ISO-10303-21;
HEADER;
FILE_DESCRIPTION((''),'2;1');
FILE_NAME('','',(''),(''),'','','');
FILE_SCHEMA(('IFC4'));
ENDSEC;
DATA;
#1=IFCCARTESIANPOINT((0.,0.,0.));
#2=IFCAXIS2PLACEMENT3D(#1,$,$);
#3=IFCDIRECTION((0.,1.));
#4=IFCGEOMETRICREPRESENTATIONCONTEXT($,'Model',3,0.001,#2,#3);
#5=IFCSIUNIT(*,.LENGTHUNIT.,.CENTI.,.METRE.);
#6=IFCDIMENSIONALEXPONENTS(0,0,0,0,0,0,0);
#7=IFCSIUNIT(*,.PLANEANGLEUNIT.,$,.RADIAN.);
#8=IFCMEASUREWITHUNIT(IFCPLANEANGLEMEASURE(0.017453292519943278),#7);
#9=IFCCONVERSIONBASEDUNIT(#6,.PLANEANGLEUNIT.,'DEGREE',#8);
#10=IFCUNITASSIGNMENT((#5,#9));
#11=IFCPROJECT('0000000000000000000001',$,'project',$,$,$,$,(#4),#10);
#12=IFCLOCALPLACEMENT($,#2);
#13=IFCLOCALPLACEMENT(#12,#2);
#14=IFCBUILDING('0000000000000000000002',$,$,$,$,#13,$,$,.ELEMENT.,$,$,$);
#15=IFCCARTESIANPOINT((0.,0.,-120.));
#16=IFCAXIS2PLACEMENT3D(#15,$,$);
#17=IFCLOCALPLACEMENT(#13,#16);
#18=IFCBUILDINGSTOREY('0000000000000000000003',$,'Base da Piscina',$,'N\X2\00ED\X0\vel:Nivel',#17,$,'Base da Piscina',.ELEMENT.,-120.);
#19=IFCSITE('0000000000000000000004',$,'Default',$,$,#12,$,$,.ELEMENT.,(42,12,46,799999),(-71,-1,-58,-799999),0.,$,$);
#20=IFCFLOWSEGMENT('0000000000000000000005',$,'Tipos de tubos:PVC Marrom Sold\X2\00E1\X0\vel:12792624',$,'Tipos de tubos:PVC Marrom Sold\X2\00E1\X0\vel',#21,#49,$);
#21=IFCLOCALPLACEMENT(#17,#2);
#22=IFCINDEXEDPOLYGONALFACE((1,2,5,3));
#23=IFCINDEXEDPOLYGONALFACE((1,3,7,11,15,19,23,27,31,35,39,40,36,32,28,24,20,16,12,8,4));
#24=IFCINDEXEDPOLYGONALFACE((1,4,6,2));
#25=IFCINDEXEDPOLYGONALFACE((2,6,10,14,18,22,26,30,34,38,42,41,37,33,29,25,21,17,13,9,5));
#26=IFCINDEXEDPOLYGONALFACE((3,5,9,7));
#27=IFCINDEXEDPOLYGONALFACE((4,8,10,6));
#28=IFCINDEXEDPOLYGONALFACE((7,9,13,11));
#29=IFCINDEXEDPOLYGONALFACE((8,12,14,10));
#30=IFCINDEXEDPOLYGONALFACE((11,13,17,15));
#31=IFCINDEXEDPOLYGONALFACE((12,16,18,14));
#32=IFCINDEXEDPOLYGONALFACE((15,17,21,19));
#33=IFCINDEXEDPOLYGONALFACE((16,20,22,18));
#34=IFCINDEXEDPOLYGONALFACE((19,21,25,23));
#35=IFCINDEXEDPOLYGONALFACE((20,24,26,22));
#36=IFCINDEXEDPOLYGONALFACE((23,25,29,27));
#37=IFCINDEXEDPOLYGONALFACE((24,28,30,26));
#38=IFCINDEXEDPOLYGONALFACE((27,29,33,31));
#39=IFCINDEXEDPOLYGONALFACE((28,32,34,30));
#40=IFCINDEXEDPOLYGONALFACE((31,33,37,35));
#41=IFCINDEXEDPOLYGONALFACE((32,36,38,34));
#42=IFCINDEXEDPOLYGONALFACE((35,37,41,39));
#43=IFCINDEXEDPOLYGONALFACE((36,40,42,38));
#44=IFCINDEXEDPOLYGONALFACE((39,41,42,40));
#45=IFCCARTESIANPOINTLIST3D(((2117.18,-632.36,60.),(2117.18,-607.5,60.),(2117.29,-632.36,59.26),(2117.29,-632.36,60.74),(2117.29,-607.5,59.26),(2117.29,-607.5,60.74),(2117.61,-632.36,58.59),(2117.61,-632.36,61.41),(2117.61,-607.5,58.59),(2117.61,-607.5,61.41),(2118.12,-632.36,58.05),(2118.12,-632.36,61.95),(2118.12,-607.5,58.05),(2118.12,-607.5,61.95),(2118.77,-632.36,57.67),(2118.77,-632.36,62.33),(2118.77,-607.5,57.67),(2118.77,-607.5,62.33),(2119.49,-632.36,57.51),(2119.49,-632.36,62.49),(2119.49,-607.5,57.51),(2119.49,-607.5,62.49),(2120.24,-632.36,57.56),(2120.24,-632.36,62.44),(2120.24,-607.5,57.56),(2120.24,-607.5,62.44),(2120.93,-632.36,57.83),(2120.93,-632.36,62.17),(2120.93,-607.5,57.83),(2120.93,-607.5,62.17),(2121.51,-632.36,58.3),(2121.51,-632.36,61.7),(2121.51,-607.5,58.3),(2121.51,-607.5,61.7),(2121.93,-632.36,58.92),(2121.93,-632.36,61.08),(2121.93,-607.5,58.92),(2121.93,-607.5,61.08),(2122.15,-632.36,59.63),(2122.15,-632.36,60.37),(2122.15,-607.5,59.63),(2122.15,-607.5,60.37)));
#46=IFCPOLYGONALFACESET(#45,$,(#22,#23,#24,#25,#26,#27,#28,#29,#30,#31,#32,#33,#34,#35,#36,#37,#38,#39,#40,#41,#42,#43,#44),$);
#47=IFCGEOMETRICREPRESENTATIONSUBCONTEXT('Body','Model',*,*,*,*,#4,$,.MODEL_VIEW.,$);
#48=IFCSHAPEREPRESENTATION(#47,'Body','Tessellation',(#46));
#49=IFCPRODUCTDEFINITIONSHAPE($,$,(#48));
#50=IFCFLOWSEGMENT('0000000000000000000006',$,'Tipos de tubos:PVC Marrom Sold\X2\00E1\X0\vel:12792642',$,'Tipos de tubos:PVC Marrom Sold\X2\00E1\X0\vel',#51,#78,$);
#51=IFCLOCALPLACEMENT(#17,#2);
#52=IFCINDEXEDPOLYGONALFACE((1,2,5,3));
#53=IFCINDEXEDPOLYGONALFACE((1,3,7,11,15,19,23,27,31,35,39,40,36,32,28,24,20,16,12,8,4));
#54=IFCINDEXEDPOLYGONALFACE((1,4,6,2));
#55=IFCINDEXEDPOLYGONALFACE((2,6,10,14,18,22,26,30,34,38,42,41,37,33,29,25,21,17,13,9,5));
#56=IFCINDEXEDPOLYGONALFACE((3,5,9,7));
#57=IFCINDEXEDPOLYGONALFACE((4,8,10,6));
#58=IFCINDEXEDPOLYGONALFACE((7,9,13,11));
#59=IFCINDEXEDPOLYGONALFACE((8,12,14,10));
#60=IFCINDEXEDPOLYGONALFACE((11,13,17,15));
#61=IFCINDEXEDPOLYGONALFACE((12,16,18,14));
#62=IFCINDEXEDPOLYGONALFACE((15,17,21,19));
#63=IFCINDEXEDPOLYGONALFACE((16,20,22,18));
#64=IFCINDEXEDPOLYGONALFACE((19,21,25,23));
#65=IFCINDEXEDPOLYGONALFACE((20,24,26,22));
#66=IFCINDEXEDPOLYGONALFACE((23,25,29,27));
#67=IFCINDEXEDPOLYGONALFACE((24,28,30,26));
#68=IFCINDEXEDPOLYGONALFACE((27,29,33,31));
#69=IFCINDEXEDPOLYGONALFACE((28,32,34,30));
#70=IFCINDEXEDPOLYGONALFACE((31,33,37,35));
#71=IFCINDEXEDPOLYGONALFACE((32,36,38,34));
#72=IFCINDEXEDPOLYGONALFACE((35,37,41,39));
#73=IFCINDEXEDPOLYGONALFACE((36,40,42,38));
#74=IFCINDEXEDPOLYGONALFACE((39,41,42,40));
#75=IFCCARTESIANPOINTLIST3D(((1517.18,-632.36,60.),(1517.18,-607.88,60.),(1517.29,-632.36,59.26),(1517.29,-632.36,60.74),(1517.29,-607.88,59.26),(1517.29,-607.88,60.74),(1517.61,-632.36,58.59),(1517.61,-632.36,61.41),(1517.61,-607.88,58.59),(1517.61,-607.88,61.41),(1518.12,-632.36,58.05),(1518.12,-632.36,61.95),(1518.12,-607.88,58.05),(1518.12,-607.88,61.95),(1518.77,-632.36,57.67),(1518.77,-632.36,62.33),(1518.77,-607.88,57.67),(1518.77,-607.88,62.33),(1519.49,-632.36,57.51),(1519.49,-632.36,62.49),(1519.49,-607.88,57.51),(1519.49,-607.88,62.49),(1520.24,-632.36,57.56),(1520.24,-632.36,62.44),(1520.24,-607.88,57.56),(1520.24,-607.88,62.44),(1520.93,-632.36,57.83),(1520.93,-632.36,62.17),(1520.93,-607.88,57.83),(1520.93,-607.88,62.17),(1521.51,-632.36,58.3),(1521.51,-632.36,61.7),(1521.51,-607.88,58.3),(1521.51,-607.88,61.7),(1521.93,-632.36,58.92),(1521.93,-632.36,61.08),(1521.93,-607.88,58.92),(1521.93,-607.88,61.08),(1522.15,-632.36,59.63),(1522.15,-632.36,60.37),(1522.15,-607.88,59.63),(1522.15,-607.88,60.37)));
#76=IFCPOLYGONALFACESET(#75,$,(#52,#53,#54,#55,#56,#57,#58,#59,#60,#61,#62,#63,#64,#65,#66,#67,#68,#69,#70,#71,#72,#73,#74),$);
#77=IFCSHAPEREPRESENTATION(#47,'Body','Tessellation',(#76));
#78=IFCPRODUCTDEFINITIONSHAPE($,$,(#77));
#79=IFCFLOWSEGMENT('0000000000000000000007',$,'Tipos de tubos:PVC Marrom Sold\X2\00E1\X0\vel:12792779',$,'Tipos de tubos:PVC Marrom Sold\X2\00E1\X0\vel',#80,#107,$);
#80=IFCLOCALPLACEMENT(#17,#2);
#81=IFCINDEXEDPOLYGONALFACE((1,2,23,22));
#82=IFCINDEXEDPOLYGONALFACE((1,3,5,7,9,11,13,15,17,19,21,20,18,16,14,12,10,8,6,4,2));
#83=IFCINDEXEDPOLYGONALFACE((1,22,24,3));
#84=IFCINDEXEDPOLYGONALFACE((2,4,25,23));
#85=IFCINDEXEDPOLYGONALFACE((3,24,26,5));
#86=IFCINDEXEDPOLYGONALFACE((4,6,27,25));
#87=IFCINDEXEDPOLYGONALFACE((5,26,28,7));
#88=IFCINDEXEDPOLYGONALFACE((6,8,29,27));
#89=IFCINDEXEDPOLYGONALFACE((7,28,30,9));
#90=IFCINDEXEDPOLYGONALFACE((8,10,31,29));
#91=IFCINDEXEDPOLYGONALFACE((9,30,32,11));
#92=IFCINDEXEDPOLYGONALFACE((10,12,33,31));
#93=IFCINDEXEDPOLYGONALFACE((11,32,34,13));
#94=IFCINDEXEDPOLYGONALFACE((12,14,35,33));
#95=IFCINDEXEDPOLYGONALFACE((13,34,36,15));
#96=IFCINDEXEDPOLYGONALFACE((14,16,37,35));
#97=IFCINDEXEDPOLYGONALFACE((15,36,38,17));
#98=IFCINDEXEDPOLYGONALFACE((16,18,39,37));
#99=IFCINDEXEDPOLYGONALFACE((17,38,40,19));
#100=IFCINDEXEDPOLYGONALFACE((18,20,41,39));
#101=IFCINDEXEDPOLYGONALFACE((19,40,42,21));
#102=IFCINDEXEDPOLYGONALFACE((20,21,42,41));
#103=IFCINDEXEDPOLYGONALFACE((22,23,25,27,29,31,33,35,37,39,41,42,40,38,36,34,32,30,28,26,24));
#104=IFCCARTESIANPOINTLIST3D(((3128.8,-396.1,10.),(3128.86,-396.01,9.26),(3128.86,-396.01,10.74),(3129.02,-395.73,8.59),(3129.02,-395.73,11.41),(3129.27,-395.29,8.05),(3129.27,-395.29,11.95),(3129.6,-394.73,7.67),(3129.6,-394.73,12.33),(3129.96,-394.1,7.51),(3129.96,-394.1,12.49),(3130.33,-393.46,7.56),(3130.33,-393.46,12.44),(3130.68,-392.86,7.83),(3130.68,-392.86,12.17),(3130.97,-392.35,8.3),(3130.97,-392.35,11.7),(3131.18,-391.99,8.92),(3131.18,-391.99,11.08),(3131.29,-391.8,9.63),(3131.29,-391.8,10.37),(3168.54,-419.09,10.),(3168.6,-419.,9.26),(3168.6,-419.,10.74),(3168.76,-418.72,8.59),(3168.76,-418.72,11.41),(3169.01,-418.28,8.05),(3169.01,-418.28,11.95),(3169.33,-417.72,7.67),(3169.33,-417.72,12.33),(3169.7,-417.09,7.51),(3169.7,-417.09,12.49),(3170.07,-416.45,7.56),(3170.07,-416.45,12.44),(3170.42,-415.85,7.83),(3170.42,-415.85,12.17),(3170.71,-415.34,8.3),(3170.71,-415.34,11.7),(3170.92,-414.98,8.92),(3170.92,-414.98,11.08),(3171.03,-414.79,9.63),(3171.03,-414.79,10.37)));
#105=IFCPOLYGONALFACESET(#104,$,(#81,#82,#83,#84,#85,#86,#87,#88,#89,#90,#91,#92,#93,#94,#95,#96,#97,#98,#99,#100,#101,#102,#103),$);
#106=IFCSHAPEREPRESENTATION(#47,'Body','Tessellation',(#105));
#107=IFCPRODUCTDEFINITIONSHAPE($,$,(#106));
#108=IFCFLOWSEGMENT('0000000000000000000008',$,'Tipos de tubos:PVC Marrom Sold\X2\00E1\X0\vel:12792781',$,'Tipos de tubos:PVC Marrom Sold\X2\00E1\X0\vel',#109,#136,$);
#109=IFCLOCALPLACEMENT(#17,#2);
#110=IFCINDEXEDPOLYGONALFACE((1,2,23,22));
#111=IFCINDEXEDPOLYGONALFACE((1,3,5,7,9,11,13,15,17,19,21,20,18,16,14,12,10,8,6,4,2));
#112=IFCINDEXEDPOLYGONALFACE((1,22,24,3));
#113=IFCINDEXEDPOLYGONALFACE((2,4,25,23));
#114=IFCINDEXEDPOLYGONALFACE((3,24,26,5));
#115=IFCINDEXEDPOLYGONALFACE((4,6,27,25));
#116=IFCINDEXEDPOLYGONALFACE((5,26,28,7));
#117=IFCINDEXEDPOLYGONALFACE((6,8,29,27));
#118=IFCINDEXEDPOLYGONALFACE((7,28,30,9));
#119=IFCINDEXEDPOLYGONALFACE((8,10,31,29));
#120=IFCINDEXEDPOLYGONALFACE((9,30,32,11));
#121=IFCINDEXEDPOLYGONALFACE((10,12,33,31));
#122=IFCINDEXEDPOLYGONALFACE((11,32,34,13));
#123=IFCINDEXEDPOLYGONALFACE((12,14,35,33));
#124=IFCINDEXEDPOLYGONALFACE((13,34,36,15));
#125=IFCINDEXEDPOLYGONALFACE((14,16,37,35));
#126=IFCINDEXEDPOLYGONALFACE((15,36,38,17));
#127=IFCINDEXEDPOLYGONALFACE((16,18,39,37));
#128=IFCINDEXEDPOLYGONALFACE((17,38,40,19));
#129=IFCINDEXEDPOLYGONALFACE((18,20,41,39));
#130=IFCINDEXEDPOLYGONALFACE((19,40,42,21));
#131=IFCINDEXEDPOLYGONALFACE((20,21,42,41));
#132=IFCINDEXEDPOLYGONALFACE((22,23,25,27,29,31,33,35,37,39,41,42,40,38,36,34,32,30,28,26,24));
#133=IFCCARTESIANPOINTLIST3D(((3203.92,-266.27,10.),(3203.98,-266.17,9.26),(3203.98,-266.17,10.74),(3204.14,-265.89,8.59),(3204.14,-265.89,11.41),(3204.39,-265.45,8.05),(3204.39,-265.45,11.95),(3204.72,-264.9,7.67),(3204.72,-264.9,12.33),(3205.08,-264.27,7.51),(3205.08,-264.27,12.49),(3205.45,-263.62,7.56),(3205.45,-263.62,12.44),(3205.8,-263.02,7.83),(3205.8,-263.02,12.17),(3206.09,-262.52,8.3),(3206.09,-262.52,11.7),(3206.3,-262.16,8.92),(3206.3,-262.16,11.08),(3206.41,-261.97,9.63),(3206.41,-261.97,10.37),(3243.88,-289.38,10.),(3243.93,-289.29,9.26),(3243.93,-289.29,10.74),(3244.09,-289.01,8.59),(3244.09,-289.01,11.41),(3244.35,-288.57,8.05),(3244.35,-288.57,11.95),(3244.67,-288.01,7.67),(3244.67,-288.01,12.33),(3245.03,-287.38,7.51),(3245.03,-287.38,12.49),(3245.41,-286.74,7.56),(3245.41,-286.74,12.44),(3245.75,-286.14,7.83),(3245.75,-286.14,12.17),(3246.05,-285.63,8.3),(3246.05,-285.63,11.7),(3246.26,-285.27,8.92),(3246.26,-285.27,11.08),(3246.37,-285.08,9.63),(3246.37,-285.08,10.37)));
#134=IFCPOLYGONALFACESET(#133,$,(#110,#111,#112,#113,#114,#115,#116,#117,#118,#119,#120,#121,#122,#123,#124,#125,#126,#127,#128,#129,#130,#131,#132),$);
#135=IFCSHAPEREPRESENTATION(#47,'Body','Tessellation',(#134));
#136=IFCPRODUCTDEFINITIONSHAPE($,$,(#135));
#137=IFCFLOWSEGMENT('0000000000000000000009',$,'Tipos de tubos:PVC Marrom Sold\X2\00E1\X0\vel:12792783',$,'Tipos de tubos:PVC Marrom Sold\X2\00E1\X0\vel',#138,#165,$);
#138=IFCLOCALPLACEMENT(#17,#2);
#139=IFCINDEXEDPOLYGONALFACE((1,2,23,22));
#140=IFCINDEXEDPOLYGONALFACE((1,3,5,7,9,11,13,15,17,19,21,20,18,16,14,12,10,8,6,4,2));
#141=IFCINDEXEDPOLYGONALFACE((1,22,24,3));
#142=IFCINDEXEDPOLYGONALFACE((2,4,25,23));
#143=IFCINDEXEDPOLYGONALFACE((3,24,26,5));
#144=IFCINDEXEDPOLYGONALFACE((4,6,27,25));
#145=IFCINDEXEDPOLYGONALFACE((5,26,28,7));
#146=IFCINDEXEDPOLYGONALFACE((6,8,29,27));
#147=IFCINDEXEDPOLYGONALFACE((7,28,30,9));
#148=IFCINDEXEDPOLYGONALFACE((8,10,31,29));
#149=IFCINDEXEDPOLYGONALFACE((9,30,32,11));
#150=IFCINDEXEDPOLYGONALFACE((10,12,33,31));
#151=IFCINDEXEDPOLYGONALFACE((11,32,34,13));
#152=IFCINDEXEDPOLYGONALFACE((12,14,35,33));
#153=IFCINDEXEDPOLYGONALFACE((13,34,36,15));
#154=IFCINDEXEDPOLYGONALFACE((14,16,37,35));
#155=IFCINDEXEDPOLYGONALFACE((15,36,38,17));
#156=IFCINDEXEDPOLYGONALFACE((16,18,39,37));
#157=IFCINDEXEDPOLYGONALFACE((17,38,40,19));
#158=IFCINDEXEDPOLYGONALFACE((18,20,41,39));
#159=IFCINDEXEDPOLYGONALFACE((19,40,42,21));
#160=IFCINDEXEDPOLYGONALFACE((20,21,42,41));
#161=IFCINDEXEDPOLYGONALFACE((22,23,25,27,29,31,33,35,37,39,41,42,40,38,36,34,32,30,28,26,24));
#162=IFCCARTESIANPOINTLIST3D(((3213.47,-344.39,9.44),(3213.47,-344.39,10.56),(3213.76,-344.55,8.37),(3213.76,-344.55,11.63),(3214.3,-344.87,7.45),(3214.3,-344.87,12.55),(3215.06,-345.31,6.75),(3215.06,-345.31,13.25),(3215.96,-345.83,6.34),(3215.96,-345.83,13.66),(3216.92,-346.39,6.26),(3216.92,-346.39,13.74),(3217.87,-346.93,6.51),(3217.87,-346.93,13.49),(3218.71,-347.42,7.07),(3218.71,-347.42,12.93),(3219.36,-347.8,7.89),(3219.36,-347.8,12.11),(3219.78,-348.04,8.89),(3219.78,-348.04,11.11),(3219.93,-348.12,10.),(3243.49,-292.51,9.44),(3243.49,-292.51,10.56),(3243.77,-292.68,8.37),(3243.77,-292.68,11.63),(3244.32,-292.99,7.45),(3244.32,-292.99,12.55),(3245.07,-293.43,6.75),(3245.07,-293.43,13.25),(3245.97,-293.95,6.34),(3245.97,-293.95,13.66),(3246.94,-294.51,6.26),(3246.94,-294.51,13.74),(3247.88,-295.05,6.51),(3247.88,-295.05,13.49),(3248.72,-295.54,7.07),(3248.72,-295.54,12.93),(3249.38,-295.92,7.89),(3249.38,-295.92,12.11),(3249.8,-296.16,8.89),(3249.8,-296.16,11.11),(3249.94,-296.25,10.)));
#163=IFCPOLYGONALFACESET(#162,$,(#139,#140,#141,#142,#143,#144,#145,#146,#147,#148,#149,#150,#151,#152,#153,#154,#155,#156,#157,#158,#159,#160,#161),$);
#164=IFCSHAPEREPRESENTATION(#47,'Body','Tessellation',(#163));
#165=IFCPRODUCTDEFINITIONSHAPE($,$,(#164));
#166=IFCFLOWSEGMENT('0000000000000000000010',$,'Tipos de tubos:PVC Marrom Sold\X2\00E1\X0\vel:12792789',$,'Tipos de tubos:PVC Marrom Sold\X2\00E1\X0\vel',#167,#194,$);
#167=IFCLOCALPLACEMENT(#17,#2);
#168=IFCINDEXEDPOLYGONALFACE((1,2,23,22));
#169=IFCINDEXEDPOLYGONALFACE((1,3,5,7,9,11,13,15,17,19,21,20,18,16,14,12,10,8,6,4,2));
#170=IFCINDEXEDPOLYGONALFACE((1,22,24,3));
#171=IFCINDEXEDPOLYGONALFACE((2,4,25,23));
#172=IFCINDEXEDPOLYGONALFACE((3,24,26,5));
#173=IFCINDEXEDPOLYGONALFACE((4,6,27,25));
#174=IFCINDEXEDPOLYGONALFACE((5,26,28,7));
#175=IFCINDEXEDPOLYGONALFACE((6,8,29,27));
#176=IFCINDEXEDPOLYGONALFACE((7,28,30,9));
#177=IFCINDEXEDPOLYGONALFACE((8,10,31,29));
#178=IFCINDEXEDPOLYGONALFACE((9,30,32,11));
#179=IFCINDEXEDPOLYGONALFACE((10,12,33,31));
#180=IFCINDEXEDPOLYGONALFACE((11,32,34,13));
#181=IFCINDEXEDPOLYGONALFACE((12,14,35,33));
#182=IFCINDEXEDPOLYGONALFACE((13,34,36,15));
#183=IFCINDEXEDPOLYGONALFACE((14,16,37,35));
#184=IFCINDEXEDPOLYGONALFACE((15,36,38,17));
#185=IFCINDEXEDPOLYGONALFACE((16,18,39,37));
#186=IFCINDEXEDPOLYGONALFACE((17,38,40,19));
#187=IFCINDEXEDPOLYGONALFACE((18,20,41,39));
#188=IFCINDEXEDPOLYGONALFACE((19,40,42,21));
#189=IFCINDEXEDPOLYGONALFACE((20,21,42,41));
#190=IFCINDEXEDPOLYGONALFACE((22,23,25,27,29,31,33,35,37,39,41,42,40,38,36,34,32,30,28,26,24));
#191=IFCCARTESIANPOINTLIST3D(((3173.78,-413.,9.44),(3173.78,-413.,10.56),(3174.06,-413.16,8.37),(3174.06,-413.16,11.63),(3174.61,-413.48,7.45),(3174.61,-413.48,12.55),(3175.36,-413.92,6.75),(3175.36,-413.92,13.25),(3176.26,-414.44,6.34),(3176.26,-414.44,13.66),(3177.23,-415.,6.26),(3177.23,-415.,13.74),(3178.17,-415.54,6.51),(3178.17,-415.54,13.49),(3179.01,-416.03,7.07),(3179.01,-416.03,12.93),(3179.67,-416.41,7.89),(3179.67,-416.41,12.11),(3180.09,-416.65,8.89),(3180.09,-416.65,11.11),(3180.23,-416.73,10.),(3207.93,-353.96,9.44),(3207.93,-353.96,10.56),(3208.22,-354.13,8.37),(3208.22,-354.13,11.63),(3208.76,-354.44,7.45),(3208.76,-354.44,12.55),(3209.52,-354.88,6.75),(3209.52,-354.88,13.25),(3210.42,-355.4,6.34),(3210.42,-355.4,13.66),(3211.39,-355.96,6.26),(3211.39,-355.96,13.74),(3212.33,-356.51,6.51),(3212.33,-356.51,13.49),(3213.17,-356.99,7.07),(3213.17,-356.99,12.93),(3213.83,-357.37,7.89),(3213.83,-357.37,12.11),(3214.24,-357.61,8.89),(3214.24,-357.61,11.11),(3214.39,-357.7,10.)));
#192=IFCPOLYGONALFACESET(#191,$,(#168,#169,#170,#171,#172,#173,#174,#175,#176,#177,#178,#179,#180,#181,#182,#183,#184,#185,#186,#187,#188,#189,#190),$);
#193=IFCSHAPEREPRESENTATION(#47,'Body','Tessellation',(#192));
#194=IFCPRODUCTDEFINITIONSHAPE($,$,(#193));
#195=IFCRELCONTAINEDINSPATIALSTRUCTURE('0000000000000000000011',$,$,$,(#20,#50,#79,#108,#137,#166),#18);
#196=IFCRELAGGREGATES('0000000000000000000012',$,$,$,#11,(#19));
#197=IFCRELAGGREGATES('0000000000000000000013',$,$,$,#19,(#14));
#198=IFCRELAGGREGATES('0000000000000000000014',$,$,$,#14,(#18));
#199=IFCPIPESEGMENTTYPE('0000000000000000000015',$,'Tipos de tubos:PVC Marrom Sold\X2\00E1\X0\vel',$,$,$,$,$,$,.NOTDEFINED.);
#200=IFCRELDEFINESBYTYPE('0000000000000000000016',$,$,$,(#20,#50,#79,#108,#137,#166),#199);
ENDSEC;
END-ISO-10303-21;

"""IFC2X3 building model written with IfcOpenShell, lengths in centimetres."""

from ifc_helpers import new_model, entity, si_unit, converted_unit, direction, frame, frame_2d, origin, origin_2d_with_axis, place, context, subcontext, project, spatial, circle, extrude, type_object, element, save


model = new_model("IFC2X3")

# Units and contexts
model_context = context("Model", 3, precision=0.001, world=origin(), true_north=direction((0.0, 1.0)))
body_context = subcontext(model_context, "Body", "Model", "MODEL_VIEW")
ifc_project = project(units=[si_unit("LENGTHUNIT", "METRE", prefix="CENTI"), converted_unit("PLANEANGLEUNIT", "DEGREE", entity("IfcPlaneAngleMeasure", 0.017453292519943278), si_unit("PLANEANGLEUNIT", "RADIAN"), dimensions=[0, 0, 0, 0, 0, 0, 0])], contexts=[model_context])

# Site, building, storey
site_placement = place(None, origin())
site = spatial("IfcSite", under=ifc_project, at=site_placement, Name="Default", CompositionType="ELEMENT", RefLatitude=(42, 12, 46, 799999), RefLongitude=(-71, -1, -58, -799999), RefElevation=0.0)
building_placement = place(site_placement, origin())
building = spatial("IfcBuilding", under=site, at=building_placement, CompositionType="ELEMENT")
storey_placement = place(building_placement, frame((0.0, 0.0, -120.0)))
storey = spatial("IfcBuildingStorey", under=building, at=storey_placement, Name="Base da Piscina", ObjectType="Nível:Nivel", LongName="Base da Piscina", CompositionType="ELEMENT", Elevation=-120.0)

# Flow segments
pipe_segment_type = type_object("IfcPipeSegmentType", Name="Tipos de tubos:PVC Marrom Soldável", PredefinedType="NOTDEFINED")
flow_segment_1_placement = place(storey_placement, origin())
element("IfcFlowSegment", 1, at=flow_segment_1_placement, inside=storey, type_object=pipe_segment_type, Name="Tipos de tubos:PVC Marrom Soldável:12792624", ObjectType="Tipos de tubos:PVC Marrom Soldável", context=body_context, shape_type="SweptSolid", body=[
    extrude(circle(Radius=2.5, at=origin_2d_with_axis()), frame((2119.68, -632.36, 60.0), z_axis=(0.0, 1.0, 0.0), x_axis=(-1.0, 0.0, 0.0)), (0.0, 0.0, 1.0), 24.86),
])
flow_segment_2_placement = place(storey_placement, origin())
element("IfcFlowSegment", 2, at=flow_segment_2_placement, inside=storey, type_object=pipe_segment_type, Name="Tipos de tubos:PVC Marrom Soldável:12792642", ObjectType="Tipos de tubos:PVC Marrom Soldável", context=body_context, shape_type="SweptSolid", body=[
    extrude(circle(Radius=2.5, at=origin_2d_with_axis()), frame((1519.68, -632.36, 60.0), z_axis=(0.0, 1.0, 0.0), x_axis=(-1.0, 0.0, 0.0)), (0.0, 0.0, 1.0), 24.48),
])
flow_segment_3_placement = place(storey_placement, origin())
element("IfcFlowSegment", 3, at=flow_segment_3_placement, inside=storey, type_object=pipe_segment_type, Name="Tipos de tubos:PVC Marrom Soldável:12792779", ObjectType="Tipos de tubos:PVC Marrom Soldável", context=body_context, shape_type="SweptSolid", body=[
    extrude(circle(Radius=2.5, at=frame_2d((0.0, 0.0), x_axis=(1.0, 0.0))), frame((3130.06, -393.94, 10.0), z_axis=(0.865569, -0.50079, 0.0), x_axis=(-0.50079, -0.865569, 0.0)), (0.0, 0.0, 1.0), 45.91),
])
flow_segment_4_placement = place(storey_placement, origin())
element("IfcFlowSegment", 4, at=flow_segment_4_placement, inside=storey, type_object=pipe_segment_type, Name="Tipos de tubos:PVC Marrom Soldável:12792781", ObjectType="Tipos de tubos:PVC Marrom Soldável", context=body_context, shape_type="SweptSolid", body=[
    extrude(circle(Radius=2.5, at=frame_2d((0.0, 0.0), x_axis=(1.0, 0.0))), frame((3205.17, -264.1, 10.0), z_axis=(0.865569, -0.50079, 0.0), x_axis=(-0.50079, -0.865569, 0.0)), (0.0, 0.0, 1.0), 46.16),
])
flow_segment_5_placement = place(storey_placement, origin())
element("IfcFlowSegment", 5, at=flow_segment_5_placement, inside=storey, type_object=pipe_segment_type, Name="Tipos de tubos:PVC Marrom Soldável:12792783", ObjectType="Tipos de tubos:PVC Marrom Soldável", context=body_context, shape_type="SweptSolid", body=[
    extrude(circle(Radius=3.75, at=origin_2d_with_axis()), frame((3216.68, -346.25, 10.0), z_axis=(0.50079, 0.865569, 0.0), x_axis=(0.865569, -0.50079, 0.0)), (0.0, 0.0, 1.0), 59.94),
])
flow_segment_6_placement = place(storey_placement, origin())
element("IfcFlowSegment", 6, at=flow_segment_6_placement, inside=storey, type_object=pipe_segment_type, Name="Tipos de tubos:PVC Marrom Soldável:12792789", ObjectType="Tipos de tubos:PVC Marrom Soldável", context=body_context, shape_type="SweptSolid", body=[
    extrude(circle(Radius=3.75, at=origin_2d_with_axis()), frame((3176.99, -414.85, 10.0), z_axis=(0.50079, 0.865569, 0.0), x_axis=(0.865569, -0.50079, 0.0)), (0.0, 0.0, 1.0), 68.2),
])

save(model, "model.ifc")
